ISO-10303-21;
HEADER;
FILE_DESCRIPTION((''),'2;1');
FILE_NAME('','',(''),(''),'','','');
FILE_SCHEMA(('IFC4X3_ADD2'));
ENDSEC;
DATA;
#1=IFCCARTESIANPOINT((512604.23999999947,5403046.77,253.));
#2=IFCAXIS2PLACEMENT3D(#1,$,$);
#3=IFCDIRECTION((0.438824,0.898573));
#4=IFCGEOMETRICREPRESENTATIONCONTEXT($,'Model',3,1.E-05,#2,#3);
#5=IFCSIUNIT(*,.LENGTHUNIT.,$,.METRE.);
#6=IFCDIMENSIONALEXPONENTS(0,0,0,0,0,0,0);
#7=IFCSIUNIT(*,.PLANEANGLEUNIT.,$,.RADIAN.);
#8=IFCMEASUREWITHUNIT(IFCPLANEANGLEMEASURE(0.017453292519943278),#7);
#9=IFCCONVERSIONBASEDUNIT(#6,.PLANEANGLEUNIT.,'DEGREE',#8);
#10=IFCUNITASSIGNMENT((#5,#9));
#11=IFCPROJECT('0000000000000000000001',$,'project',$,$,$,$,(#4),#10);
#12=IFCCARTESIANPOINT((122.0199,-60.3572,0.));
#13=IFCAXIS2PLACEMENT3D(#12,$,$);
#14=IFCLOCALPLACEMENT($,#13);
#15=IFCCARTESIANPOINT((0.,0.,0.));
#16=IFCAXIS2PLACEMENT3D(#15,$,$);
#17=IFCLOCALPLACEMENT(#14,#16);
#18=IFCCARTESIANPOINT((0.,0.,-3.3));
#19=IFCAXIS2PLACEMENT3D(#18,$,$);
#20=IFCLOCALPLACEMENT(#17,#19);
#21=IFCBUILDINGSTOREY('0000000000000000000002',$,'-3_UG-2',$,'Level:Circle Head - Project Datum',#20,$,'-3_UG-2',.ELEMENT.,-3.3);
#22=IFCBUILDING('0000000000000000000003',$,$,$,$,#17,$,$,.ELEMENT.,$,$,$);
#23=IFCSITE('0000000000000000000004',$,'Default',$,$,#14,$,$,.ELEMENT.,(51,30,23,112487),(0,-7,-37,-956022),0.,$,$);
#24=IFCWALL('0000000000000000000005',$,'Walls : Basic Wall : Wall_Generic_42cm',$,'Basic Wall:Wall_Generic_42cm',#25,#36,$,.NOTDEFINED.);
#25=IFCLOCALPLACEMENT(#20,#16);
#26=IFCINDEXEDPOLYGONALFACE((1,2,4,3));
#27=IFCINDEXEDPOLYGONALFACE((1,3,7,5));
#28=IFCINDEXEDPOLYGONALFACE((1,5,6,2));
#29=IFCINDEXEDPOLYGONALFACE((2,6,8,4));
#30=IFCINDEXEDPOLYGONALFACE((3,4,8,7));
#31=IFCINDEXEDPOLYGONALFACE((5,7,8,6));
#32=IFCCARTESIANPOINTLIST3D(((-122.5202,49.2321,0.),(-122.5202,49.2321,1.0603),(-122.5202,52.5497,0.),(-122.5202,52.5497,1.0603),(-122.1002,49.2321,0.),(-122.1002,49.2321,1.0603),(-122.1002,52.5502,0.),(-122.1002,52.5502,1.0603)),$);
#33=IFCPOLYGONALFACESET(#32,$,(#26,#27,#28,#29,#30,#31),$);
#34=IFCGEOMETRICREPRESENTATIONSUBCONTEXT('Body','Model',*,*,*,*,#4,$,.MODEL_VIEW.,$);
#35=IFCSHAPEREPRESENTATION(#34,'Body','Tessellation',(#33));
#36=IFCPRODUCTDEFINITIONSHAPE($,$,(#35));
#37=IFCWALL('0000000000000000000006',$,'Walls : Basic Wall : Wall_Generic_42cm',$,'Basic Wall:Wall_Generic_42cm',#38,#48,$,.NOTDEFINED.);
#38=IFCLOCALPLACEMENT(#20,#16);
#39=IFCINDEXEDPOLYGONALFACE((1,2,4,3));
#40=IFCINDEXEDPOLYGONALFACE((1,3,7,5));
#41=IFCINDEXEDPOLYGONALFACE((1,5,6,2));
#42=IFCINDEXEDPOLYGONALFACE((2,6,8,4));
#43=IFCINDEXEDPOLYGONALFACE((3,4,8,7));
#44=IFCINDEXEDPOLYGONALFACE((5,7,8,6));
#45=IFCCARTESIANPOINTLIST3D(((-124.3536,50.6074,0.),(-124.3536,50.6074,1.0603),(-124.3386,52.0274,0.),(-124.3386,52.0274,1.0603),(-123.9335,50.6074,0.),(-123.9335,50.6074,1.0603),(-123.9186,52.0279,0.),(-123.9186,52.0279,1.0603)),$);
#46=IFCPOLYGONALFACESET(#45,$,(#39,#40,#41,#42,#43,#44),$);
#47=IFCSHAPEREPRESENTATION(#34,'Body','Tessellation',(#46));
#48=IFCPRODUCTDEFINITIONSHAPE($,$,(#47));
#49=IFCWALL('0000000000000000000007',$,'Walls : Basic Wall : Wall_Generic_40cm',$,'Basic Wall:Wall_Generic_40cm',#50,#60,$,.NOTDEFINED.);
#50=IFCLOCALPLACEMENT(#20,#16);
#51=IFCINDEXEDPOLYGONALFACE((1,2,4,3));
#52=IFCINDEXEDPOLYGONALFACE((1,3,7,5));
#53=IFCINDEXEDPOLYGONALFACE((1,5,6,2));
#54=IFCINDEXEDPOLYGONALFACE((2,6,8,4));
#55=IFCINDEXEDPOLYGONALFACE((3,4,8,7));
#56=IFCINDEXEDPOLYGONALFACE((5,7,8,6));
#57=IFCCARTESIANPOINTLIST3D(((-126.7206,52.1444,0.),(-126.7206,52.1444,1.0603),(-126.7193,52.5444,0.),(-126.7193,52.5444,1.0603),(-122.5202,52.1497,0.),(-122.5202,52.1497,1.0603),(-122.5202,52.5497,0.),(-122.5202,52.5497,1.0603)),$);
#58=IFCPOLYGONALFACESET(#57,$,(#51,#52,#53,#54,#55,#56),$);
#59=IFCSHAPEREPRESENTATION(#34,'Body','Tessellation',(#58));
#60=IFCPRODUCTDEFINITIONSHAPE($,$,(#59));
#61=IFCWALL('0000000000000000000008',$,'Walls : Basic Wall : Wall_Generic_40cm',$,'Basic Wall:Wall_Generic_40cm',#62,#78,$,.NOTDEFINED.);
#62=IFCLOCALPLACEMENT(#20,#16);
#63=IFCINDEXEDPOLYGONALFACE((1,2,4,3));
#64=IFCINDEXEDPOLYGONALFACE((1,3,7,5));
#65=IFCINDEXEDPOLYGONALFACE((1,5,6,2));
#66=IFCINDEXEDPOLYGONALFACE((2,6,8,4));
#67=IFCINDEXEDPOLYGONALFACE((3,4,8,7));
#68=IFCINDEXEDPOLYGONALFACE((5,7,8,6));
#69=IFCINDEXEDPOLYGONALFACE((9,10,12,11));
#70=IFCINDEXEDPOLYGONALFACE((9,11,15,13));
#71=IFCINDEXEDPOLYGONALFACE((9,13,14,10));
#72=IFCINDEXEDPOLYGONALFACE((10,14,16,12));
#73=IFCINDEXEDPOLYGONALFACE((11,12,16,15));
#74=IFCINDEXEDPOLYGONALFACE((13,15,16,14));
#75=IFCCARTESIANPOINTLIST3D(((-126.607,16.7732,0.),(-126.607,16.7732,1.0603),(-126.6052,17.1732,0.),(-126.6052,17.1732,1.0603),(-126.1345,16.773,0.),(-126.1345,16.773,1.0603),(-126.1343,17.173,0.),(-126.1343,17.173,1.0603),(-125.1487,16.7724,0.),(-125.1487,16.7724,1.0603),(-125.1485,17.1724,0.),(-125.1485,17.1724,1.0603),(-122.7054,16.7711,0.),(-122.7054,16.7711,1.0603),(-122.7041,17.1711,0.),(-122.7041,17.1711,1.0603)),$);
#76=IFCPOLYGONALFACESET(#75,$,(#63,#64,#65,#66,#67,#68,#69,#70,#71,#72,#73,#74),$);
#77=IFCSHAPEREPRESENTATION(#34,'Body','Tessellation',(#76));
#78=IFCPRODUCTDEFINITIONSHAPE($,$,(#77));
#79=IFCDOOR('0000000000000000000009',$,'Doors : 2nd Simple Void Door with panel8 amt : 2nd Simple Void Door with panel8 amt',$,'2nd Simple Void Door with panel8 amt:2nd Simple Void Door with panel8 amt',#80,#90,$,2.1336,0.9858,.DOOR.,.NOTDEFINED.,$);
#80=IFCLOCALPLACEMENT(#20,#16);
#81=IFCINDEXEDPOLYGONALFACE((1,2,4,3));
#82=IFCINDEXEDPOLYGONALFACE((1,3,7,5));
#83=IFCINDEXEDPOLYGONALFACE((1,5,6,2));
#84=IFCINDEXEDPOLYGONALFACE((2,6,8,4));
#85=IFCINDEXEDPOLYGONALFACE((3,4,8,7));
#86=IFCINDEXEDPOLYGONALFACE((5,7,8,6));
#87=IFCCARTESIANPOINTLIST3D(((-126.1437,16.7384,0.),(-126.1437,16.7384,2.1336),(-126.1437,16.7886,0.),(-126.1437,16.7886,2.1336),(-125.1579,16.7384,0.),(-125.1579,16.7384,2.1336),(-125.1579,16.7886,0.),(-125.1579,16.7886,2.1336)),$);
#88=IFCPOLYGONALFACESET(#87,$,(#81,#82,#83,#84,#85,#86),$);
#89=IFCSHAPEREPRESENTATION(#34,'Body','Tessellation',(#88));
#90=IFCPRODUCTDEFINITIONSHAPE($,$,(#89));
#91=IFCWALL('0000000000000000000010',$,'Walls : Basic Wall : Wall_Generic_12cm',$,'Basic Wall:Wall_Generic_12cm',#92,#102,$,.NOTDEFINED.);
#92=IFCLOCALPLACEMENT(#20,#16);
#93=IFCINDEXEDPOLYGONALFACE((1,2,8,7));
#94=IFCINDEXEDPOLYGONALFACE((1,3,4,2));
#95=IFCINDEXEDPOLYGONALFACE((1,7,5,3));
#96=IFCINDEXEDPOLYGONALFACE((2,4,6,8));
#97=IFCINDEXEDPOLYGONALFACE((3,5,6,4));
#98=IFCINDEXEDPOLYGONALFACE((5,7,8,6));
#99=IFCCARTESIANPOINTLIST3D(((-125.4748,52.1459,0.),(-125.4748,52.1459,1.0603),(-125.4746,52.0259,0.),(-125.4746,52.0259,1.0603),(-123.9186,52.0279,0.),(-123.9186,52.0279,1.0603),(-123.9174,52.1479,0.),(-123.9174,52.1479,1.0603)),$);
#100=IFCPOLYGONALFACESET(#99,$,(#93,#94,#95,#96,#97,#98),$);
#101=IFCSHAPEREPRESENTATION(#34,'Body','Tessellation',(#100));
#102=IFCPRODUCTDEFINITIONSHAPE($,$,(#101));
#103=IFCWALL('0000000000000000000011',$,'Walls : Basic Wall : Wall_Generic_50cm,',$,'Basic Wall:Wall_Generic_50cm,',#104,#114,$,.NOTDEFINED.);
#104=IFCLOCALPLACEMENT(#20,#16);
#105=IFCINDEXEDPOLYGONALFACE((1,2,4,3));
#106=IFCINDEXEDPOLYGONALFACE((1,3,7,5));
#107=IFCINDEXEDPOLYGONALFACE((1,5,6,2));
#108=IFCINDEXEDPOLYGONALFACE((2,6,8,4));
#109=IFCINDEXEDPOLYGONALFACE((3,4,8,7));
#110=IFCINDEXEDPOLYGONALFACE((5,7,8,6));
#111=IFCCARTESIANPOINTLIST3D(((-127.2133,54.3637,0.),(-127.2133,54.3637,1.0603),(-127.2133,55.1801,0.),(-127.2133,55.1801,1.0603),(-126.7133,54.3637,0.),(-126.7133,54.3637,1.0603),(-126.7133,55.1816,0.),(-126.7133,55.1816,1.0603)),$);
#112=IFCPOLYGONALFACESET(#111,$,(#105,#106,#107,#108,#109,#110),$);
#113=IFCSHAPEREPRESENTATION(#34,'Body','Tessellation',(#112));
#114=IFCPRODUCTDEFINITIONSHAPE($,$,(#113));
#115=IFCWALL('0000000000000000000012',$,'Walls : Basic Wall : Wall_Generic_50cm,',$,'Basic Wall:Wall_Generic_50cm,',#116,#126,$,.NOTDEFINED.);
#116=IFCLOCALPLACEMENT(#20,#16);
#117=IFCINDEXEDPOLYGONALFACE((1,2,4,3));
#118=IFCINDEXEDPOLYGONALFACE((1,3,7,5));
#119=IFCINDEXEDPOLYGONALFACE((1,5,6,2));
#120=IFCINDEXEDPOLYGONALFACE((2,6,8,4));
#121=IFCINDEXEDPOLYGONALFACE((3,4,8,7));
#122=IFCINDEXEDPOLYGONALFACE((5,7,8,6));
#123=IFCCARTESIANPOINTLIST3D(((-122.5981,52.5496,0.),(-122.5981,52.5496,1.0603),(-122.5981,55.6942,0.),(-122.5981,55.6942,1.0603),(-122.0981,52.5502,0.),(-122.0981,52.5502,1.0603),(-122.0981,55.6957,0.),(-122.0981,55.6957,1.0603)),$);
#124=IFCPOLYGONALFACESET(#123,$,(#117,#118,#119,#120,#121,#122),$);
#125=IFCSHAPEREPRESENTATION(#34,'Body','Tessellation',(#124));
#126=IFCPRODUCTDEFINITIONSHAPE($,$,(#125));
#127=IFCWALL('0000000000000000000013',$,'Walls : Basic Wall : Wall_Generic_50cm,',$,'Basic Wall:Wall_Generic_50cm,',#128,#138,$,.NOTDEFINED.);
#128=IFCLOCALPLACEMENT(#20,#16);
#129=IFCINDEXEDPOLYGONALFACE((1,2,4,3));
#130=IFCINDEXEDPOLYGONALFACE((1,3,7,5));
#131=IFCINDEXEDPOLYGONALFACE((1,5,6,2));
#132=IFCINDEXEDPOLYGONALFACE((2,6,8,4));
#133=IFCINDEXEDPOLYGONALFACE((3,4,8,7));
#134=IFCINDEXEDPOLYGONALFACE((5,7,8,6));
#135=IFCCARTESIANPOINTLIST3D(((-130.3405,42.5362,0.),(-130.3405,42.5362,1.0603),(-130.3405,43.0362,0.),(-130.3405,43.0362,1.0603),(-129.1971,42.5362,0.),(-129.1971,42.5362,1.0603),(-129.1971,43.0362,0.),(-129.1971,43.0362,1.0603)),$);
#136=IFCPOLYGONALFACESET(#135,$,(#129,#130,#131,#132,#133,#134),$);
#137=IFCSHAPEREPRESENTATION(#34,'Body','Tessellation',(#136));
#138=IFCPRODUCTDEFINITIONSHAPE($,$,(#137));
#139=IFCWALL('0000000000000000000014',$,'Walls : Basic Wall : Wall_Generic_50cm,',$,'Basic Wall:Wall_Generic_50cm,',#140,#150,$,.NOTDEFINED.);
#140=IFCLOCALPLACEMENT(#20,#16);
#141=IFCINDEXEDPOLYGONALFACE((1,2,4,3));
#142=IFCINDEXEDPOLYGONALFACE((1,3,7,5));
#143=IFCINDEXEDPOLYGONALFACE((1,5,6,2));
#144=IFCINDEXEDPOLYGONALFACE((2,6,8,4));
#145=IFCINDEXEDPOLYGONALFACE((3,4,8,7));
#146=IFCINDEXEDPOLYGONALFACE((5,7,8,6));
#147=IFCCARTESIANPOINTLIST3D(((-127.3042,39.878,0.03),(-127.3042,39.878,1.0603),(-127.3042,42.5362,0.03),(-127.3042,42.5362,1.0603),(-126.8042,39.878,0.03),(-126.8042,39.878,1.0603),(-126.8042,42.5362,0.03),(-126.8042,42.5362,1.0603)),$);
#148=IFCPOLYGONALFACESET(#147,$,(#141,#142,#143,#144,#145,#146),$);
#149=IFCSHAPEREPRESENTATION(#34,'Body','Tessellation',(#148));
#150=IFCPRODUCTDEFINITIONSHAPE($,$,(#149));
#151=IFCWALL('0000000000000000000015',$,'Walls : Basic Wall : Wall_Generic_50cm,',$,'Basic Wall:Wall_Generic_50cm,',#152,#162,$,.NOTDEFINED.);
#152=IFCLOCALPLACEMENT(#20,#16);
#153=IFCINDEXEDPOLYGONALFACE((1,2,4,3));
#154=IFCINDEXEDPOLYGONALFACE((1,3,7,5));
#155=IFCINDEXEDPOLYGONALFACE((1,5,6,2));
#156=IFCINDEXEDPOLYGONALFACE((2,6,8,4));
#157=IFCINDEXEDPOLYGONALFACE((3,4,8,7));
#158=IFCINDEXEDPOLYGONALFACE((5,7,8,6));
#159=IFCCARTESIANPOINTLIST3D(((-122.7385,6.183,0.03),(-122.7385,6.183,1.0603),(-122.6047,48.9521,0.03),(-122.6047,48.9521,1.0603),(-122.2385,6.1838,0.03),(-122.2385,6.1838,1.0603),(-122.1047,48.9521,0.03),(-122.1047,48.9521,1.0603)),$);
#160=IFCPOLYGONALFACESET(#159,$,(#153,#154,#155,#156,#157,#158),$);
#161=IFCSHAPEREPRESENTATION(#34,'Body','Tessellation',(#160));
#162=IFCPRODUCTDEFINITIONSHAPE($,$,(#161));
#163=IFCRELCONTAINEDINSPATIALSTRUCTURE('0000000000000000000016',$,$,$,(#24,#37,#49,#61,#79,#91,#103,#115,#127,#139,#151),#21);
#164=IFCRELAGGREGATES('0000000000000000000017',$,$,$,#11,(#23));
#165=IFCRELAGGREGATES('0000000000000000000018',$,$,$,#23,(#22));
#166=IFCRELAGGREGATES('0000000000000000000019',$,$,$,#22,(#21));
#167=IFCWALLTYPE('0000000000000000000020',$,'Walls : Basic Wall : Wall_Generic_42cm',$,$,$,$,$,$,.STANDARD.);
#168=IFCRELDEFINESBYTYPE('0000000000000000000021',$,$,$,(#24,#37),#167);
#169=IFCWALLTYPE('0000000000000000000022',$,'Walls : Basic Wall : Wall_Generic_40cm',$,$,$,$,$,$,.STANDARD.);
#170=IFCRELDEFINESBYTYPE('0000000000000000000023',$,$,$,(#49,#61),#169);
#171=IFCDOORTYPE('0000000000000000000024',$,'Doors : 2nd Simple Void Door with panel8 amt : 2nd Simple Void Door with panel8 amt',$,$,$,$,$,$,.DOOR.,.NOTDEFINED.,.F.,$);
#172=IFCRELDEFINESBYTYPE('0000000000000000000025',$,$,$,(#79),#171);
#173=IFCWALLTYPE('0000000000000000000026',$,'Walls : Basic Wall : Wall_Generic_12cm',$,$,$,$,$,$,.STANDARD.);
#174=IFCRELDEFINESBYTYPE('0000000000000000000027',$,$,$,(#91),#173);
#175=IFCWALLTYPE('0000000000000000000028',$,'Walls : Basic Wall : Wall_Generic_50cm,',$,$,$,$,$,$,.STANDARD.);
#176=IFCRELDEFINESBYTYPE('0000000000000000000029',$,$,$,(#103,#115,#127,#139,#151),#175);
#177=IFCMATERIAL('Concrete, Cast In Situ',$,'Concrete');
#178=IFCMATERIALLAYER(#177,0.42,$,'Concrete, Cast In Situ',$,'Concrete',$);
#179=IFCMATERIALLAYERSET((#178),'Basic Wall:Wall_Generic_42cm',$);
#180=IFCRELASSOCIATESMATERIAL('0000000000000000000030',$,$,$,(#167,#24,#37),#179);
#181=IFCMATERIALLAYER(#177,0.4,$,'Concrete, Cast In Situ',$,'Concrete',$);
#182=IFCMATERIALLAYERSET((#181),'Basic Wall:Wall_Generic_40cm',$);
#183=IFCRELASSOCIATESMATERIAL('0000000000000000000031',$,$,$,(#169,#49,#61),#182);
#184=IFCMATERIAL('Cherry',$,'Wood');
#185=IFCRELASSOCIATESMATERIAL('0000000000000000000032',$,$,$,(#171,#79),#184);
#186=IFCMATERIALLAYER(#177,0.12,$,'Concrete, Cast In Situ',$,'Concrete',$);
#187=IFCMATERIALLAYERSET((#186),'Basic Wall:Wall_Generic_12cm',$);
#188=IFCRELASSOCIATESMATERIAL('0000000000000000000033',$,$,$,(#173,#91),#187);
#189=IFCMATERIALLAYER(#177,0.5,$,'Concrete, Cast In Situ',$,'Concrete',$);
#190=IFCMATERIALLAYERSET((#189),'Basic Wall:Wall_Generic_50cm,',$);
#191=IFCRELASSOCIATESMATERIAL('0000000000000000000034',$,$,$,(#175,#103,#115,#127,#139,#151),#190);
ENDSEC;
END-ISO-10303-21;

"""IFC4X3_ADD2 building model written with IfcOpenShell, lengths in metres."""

from ifc_helpers import new_model, entity, si_unit, converted_unit, direction, frame, frame_2d, origin, place, context, subcontext, project, spatial, polyline, rectangle, outline, extrude, clip, halfspace, source, transform, mapped, material, layer, layer_set, type_object, type_shapes, element, fill, save


model = new_model("IFC4X3_ADD2")

# Units and contexts
model_context = context("Model", 3, precision=1e-05, world=frame((512604.23999999947, 5403046.77, 253.0)), true_north=direction((0.438824, 0.898573)))
body_context = subcontext(model_context, "Body", "Model", "MODEL_VIEW")
ifc_project = project(units=[si_unit("LENGTHUNIT", "METRE"), converted_unit("PLANEANGLEUNIT", "DEGREE", entity("IfcPlaneAngleMeasure", 0.017453292519943278), si_unit("PLANEANGLEUNIT", "RADIAN"), dimensions=[0, 0, 0, 0, 0, 0, 0])], contexts=[model_context])

# Site, building, storey
site_placement = place(None, frame((122.0199, -60.3572, 0.0)))
site = spatial("IfcSite", under=ifc_project, at=site_placement, Name="Default", CompositionType="ELEMENT", RefLatitude=(51, 30, 23, 112487), RefLongitude=(0, -7, -37, -956022), RefElevation=0.0)
building_placement = place(site_placement, origin())
building = spatial("IfcBuilding", under=site, at=building_placement, CompositionType="ELEMENT")
storey_placement = place(building_placement, frame((0.0, 0.0, -3.3)))
storey = spatial("IfcBuildingStorey", under=building, at=storey_placement, Name="-3_UG-2", ObjectType="Level:Circle Head - Project Datum", LongName="-3_UG-2", CompositionType="ELEMENT", Elevation=-3.3)

# Walls
ifc_material_1 = material(Name="Concrete, Cast In Situ", Category="Concrete")
ifc_layer_1 = layer(ifc_material_1, 0.42, Name="Concrete, Cast In Situ", Category="Concrete")
ifc_layer_set_1 = layer_set([ifc_layer_1], Name="Basic Wall:Wall_Generic_42cm")
wall_type_1 = type_object("IfcWallType", Name="Walls : Basic Wall : Wall_Generic_42cm", PredefinedType="STANDARD", material=ifc_layer_set_1)
wall_1_placement = place(storey_placement, frame((-122.3102, 49.2321, 0.0), z_axis=(0.0, 0.0, 1.0), x_axis=(0.0, 1.0, 0.0)))
element("IfcWall", 1, at=wall_1_placement, inside=storey, type_object=wall_type_1, material=ifc_layer_set_1, Name="Walls : Basic Wall : Wall_Generic_42cm", ObjectType="Basic Wall:Wall_Generic_42cm", PredefinedType="NOTDEFINED", context=body_context, shape_type="Clipping", body=[
    clip(extrude(outline(polyline([(3.3182, -0.21), (3.3176, 0.21), (2.9176, 0.21), (0.0, 0.21), (0.0, -0.2064), (0.0, -0.21), (3.3182, -0.21)])), origin(), (0.0, 0.0, 1.0), 1.0603), halfspace(origin(), True)),
])
wall_2_placement = place(storey_placement, frame((-124.1286, 52.0301, 0.0), z_axis=(0.0, 0.0, 1.0), x_axis=(-0.010506, -0.999945, 0.0)))
element("IfcWall", 2, at=wall_2_placement, inside=storey, type_object=wall_type_1, material=ifc_layer_set_1, Name="Walls : Basic Wall : Wall_Generic_42cm", ObjectType="Basic Wall:Wall_Generic_42cm", PredefinedType="NOTDEFINED", context=body_context, shape_type="Clipping", body=[
    clip(extrude(outline(polyline([(1.425, -0.21), (1.4206, 0.21), (1.1142, 0.21), (0.0, 0.21), (0.0049, -0.21), (1.165, -0.21), (1.425, -0.21)])), origin(), (0.0, 0.0, 1.0), 1.0603), halfspace(origin(), True)),
])
ifc_layer_2 = layer(ifc_material_1, 0.4, Name="Concrete, Cast In Situ", Category="Concrete")
ifc_layer_set_2 = layer_set([ifc_layer_2], Name="Basic Wall:Wall_Generic_40cm")
wall_type_2 = type_object("IfcWallType", Name="Walls : Basic Wall : Wall_Generic_40cm", PredefinedType="STANDARD", material=ifc_layer_set_2)
wall_3_placement = place(storey_placement, frame((-126.7209, 52.3444, 0.0), z_axis=(0.0, 0.0, 1.0), x_axis=(0.999999, 0.001273, 0.0)))
element("IfcWall", 3, at=wall_3_placement, inside=storey, type_object=wall_type_2, material=ifc_layer_set_2, Name="Walls : Basic Wall : Wall_Generic_40cm", ObjectType="Basic Wall:Wall_Generic_40cm", PredefinedType="NOTDEFINED", context=body_context, shape_type="Clipping", body=[
    clip(extrude(outline(polyline([(0.0018, 0.2), (0.0, -0.2), (1.2459, -0.2), (2.8033, -0.2), (3.0403, -0.2), (4.2005, -0.2), (4.201, 0.2), (4.1231, 0.2), (0.0018, 0.2)])), origin(), (0.0, 0.0, 1.0), 1.0603), halfspace(origin(), True)),
])

# Wall, opening, door
wall_4_placement = place(storey_placement, frame((-126.6069, 16.9732, 0.0), z_axis=(0.0, 0.0, 1.0), x_axis=(1.0, -0.000544, 0.0)))
wall_4 = element("IfcWall", 4, at=wall_4_placement, inside=storey, type_object=wall_type_2, material=ifc_layer_set_2, Name="Walls : Basic Wall : Wall_Generic_40cm", ObjectType="Basic Wall:Wall_Generic_40cm", PredefinedType="NOTDEFINED", context=body_context, shape_type="Clipping", body=[
    clip(extrude(outline(polyline([(0.0, -0.2), (3.9016, -0.2), (3.9027, 0.2), (0.0016, 0.2), (0.0, -0.2)])), origin(), (0.0, 0.0, 1.0), 1.0603), halfspace(origin(), True)),
])
opening_1_placement = place(wall_4_placement, frame((126.6161, -16.9044, 0.0), z_axis=(0.0, 0.0, 1.0), x_axis=(1.0, 0.000544, 0.0)))
opening_1 = element("IfcOpeningElement", 5, at=opening_1_placement, cuts=wall_4, PredefinedType="OPENING", context=body_context, shape_type="SweptSolid", body=[
    extrude(rectangle(XDim=2.1336, YDim=0.9858, at=frame_2d((0.0, 0.0), x_axis=(0.0, 1.0))), frame((-125.6416, 16.7727, 1.0668), z_axis=(0.000544, 1.0, 0.0), x_axis=(1.0, -0.000544, 0.0)), (0.0, 0.0, 1.0), 0.4),
])
ifc_material_2 = material(Name="Cherry", Category="Wood")
door_type_1 = type_object("IfcDoorType", Name="Doors : 2nd Simple Void Door with panel8 amt : 2nd Simple Void Door with panel8 amt", OperationType="NOTDEFINED", ParameterTakesPrecedence=False, PredefinedType="DOOR", material=ifc_material_2)
shared_shape_1 = source(origin(), body_context, "Body", "SweptSolid", [
    extrude(rectangle(XDim=0.9858, YDim=0.0501, at=frame_2d((0.0, 0.0), x_axis=(1.0, 0.0))), frame((0.4929, 0.0594, 0.0)), (0.0, 0.0, 1.0), 2.1336),
])
type_shapes(door_type_1, [shared_shape_1])
door_1_placement = place(opening_1_placement, frame((-126.1437, 16.7041, 0.0)))
door_1 = element("IfcDoor", 6, at=door_1_placement, inside=storey, type_object=door_type_1, material=ifc_material_2, Name="Doors : 2nd Simple Void Door with panel8 amt : 2nd Simple Void Door with panel8 amt", ObjectType="2nd Simple Void Door with panel8 amt:2nd Simple Void Door with panel8 amt", OperationType="NOTDEFINED", OverallHeight=2.1336, OverallWidth=0.9858, PredefinedType="DOOR", context=body_context, shape_type="MappedRepresentation", body=[
    mapped(shared_shape_1, transform((0.0, 0.0, 0.0), scale=1.0)),
])
fill(opening_1, door_1)

# Walls
ifc_layer_3 = layer(ifc_material_1, 0.12, Name="Concrete, Cast In Situ", Category="Concrete")
ifc_layer_set_3 = layer_set([ifc_layer_3], Name="Basic Wall:Wall_Generic_12cm")
wall_type_3 = type_object("IfcWallType", Name="Walls : Basic Wall : Wall_Generic_12cm", PredefinedType="STANDARD", material=ifc_layer_set_3)
wall_5_placement = place(storey_placement, frame((-125.4747, 52.0859, 0.0), z_axis=(0.0, 0.0, 1.0), x_axis=(0.999999, 0.001273, 0.0)))
element("IfcWall", 7, at=wall_5_placement, inside=storey, type_object=wall_type_3, material=ifc_layer_set_3, Name="Walls : Basic Wall : Wall_Generic_12cm", ObjectType="Basic Wall:Wall_Generic_12cm", PredefinedType="NOTDEFINED", context=body_context, shape_type="Clipping", body=[
    clip(extrude(outline(polyline([(1.556, -0.06), (1.5574, 0.06), (0.0, 0.06), (0.0, -0.06), (1.136, -0.06), (1.556, -0.06)])), origin(), (0.0, 0.0, 1.0), 1.0603), halfspace(origin(), True)),
])
ifc_layer_4 = layer(ifc_material_1, 0.5, Name="Concrete, Cast In Situ", Category="Concrete")
ifc_layer_set_4 = layer_set([ifc_layer_4], Name="Basic Wall:Wall_Generic_50cm,")
wall_type_4 = type_object("IfcWallType", Name="Walls : Basic Wall : Wall_Generic_50cm,", PredefinedType="STANDARD", material=ifc_layer_set_4)
wall_6_placement = place(storey_placement, frame((-126.9633, 55.1816, 0.0), z_axis=(0.0, 0.0, 1.0), x_axis=(0.0, -1.0, 0.0)))
element("IfcWall", 8, at=wall_6_placement, inside=storey, type_object=wall_type_4, material=ifc_layer_set_4, Name="Walls : Basic Wall : Wall_Generic_50cm,", ObjectType="Basic Wall:Wall_Generic_50cm,", PredefinedType="NOTDEFINED", context=body_context, shape_type="Clipping", body=[
    clip(extrude(outline(polyline([(0.818, -0.25), (0.818, 0.25), (0.0, 0.25), (0.0015, -0.25), (0.818, -0.25)])), origin(), (0.0, 0.0, 1.0), 1.0603), halfspace(origin(), True)),
])
wall_7_placement = place(storey_placement, frame((-122.3481, 55.6957, 0.0), z_axis=(0.0, 0.0, 1.0), x_axis=(0.0, -1.0, 0.0)))
element("IfcWall", 9, at=wall_7_placement, inside=storey, type_object=wall_type_4, material=ifc_layer_set_4, Name="Walls : Basic Wall : Wall_Generic_50cm,", ObjectType="Basic Wall:Wall_Generic_50cm,", PredefinedType="NOTDEFINED", context=body_context, shape_type="Clipping", body=[
    clip(extrude(outline(polyline([(3.1461, -0.25), (3.146, -0.1721), (3.1455, 0.2479), (3.1455, 0.25), (0.0, 0.25), (0.0015, -0.25), (3.1461, -0.25)])), origin(), (0.0, 0.0, 1.0), 1.0603), halfspace(origin(), True)),
])
wall_8_placement = place(storey_placement, frame((-129.1971, 42.7862, 0.0), z_axis=(0.0, 0.0, 1.0), x_axis=(-1.0, 0.0, 0.0)))
element("IfcWall", 10, at=wall_8_placement, inside=storey, type_object=wall_type_4, material=ifc_layer_set_4, Name="Walls : Basic Wall : Wall_Generic_50cm,", ObjectType="Basic Wall:Wall_Generic_50cm,", PredefinedType="NOTDEFINED", context=body_context, shape_type="Clipping", body=[
    clip(extrude(rectangle(XDim=1.1434, YDim=0.5, at=frame_2d((0.5717, 0.0), x_axis=(-1.0, 0.0))), origin(), (0.0, 0.0, 1.0), 1.0603), halfspace(origin(), True)),
])
wall_9_placement = place(storey_placement, frame((-127.0542, 42.5362, 0.03), z_axis=(0.0, 0.0, 1.0), x_axis=(0.0, -1.0, 0.0)))
element("IfcWall", 11, at=wall_9_placement, inside=storey, type_object=wall_type_4, material=ifc_layer_set_4, Name="Walls : Basic Wall : Wall_Generic_50cm,", ObjectType="Basic Wall:Wall_Generic_50cm,", PredefinedType="NOTDEFINED", context=body_context, shape_type="Clipping", body=[
    clip(extrude(rectangle(XDim=2.6582, YDim=0.5, at=frame_2d((1.3291, 0.0), x_axis=(-1.0, 0.0))), origin(), (0.0, 0.0, 1.0), 1.0303), halfspace(origin(), True)),
])
wall_10_placement = place(storey_placement, frame((-122.3547, 48.9528, 0.03), z_axis=(0.0, 0.0, 1.0), x_axis=(-0.003127, -0.999995, 0.0)))
element("IfcWall", 12, at=wall_10_placement, inside=storey, type_object=wall_type_4, material=ifc_layer_set_4, Name="Walls : Basic Wall : Wall_Generic_50cm,", ObjectType="Basic Wall:Wall_Generic_50cm,", PredefinedType="NOTDEFINED", context=body_context, shape_type="Clipping", body=[
    clip(extrude(outline(polyline([(42.7708, -0.25), (42.7684, 0.25), (0.0, 0.25), (0.0016, -0.25), (42.7708, -0.25)])), origin(), (0.0, 0.0, 1.0), 1.0303), halfspace(origin(), True)),
])

save(model, "model.ifc")
